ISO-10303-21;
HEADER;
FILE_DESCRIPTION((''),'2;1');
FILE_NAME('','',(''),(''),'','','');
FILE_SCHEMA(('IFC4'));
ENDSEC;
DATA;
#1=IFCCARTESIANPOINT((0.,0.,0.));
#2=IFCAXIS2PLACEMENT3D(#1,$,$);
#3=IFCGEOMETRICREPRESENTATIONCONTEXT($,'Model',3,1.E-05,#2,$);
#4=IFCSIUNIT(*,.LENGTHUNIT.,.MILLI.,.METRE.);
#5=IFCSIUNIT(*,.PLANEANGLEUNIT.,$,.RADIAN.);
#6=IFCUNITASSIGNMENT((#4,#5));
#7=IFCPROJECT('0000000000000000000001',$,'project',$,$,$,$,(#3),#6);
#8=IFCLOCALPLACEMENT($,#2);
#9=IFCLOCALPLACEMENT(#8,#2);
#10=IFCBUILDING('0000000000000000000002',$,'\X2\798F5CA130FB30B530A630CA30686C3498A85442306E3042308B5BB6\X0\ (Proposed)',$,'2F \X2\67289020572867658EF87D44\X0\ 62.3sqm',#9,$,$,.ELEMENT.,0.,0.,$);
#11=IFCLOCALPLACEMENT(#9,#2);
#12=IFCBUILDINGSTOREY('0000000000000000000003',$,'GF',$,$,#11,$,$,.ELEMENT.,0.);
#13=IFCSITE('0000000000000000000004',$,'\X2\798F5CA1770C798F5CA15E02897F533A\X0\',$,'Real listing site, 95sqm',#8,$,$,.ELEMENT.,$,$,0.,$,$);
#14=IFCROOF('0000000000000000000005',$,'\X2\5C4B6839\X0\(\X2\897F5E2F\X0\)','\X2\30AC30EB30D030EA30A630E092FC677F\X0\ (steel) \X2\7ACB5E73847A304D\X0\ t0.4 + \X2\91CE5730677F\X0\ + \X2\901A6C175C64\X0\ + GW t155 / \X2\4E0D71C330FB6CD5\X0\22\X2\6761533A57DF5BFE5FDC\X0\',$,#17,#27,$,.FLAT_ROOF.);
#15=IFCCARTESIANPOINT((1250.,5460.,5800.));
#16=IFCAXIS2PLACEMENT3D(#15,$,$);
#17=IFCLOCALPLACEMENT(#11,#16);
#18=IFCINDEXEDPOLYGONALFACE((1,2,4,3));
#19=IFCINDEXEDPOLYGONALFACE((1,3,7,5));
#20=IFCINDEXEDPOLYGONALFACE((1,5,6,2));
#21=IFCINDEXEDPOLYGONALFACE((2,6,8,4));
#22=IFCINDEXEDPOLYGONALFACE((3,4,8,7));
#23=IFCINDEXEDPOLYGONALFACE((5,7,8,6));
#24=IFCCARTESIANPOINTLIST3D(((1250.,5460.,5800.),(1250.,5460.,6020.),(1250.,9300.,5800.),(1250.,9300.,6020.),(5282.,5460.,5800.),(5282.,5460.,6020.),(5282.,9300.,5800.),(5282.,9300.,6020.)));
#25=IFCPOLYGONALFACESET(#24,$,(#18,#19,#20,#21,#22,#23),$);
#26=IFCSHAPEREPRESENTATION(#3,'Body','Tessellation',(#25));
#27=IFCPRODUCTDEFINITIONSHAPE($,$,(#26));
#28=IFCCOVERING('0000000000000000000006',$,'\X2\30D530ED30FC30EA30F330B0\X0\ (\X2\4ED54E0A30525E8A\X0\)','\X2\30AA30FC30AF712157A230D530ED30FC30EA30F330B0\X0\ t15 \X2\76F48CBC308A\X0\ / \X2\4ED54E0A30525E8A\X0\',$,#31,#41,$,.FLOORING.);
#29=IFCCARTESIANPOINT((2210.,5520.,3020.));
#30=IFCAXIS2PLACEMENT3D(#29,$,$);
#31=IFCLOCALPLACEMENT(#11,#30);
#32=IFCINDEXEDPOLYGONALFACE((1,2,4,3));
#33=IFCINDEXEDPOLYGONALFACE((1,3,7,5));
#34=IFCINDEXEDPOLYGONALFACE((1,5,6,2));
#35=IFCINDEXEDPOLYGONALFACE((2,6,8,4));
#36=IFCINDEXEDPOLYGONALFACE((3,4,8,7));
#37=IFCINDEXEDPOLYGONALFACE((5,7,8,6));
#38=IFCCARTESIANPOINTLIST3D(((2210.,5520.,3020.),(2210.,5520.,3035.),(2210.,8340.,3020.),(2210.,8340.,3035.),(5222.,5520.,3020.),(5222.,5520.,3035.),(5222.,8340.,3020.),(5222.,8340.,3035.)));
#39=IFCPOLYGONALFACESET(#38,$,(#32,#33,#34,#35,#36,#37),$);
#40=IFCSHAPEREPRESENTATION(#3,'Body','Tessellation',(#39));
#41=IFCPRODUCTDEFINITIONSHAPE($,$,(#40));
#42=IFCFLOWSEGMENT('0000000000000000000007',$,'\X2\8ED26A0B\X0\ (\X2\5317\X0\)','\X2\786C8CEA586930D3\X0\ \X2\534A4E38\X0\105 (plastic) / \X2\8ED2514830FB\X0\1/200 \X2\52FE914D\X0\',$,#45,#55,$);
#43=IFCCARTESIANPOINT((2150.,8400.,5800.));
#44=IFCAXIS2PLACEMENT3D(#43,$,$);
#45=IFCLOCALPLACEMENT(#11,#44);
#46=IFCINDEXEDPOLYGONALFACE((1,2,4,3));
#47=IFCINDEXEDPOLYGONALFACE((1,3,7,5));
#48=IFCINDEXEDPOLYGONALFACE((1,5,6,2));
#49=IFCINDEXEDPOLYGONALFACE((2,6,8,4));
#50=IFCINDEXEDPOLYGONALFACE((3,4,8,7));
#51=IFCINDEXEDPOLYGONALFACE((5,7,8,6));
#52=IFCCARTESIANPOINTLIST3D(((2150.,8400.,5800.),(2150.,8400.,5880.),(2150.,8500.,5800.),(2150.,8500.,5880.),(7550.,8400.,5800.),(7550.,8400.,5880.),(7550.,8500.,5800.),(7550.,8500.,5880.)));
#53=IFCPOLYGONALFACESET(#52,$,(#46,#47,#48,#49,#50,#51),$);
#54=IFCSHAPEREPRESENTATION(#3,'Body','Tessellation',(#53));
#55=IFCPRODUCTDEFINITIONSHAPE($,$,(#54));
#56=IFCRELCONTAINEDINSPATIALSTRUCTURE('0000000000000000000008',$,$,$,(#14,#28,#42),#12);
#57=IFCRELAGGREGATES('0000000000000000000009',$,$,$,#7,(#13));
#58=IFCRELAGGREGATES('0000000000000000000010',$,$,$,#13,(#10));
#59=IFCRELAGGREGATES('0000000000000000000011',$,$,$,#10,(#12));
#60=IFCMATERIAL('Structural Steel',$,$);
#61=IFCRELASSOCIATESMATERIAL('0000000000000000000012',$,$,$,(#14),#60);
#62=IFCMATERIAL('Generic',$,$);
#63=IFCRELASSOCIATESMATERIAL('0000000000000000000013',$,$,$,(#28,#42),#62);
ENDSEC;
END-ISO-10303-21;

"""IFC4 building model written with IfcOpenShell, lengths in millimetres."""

from ifc_helpers import new_model, si_unit, frame, frame_2d, origin, place, context, project, spatial, rectangle, extrude, material, element, save


model = new_model("IFC4")

# Units and contexts
model_context = context("Model", 3, precision=1e-05, world=origin())
ifc_project = project(units=[si_unit("LENGTHUNIT", "METRE", prefix="MILLI"), si_unit("PLANEANGLEUNIT", "RADIAN")], contexts=[model_context])

# Site, building, storey
site_placement = place(None, origin())
site = spatial("IfcSite", under=ifc_project, at=site_placement, Name="福岡県福岡市西区", ObjectType="Real listing site, 95sqm", CompositionType="ELEMENT", RefElevation=0.0)
building_placement = place(site_placement, origin())
building = spatial("IfcBuilding", under=site, at=building_placement, Name="福岡・サウナと水風呂のある家 (Proposed)", ObjectType="2F 木造在来軸組 62.3sqm", CompositionType="ELEMENT", ElevationOfRefHeight=0.0, ElevationOfTerrain=0.0)
storey_placement = place(building_placement, origin())
storey = spatial("IfcBuildingStorey", under=building, at=storey_placement, Name="GF", CompositionType="ELEMENT", Elevation=0.0)

# Roof
ifc_material_1 = material(Name="Structural Steel")
for number, where, name in (
    (1, (1250.0, 5460.0, 5800.0), "屋根(西帯)"),
):
    element("IfcRoof", number, at=place(storey_placement, frame(where)), inside=storey, material=ifc_material_1, Name=name, Description="ガルバリウム鋼板 (steel) 立平葺き t0.4 + 野地板 + 通気層 + GW t155 / 不燃・法22条区域対応", PredefinedType="FLAT_ROOF", context=model_context, shape_type="SweptSolid", body=[
        extrude(rectangle(XDim=4032.0, YDim=3840.0, at=frame_2d((2016.0, 1920.0))), frame((1250.0, 5460.0, 5800.0)), (0.0, 0.0, 1.0), 220.0),
    ])

# Covering
ifc_material_2 = material(Name="Generic")
covering_placement = place(storey_placement, frame((2210.0, 5520.0, 3020.0)))
element("IfcCovering", 2, at=covering_placement, inside=storey, material=ifc_material_2, Name="フローリング (仕上げ床)", Description="オーク無垢フローリング t15 直貼り / 仕上げ床", PredefinedType="FLOORING", context=model_context, shape_type="SweptSolid", body=[
    extrude(rectangle(XDim=3012.0, YDim=2820.0, at=frame_2d((1506.0, 1410.0))), frame((2210.0, 5520.0, 3020.0)), (0.0, 0.0, 1.0), 15.0),
])

# Flow segment
flow_segment_placement = place(storey_placement, frame((2150.0, 8400.0, 5800.0)))
element("IfcFlowSegment", 3, at=flow_segment_placement, inside=storey, material=ifc_material_2, Name="軒樋 (北)", Description="硬質塩ビ 半丸105 (plastic) / 軒先・1/200 勾配", context=model_context, shape_type="SweptSolid", body=[
    extrude(rectangle(XDim=5400.0, YDim=100.0, at=frame_2d((2700.0, 50.0))), frame((2150.0, 8400.0, 5800.0)), (0.0, 0.0, 1.0), 80.0),
])

save(model, "model.ifc")
